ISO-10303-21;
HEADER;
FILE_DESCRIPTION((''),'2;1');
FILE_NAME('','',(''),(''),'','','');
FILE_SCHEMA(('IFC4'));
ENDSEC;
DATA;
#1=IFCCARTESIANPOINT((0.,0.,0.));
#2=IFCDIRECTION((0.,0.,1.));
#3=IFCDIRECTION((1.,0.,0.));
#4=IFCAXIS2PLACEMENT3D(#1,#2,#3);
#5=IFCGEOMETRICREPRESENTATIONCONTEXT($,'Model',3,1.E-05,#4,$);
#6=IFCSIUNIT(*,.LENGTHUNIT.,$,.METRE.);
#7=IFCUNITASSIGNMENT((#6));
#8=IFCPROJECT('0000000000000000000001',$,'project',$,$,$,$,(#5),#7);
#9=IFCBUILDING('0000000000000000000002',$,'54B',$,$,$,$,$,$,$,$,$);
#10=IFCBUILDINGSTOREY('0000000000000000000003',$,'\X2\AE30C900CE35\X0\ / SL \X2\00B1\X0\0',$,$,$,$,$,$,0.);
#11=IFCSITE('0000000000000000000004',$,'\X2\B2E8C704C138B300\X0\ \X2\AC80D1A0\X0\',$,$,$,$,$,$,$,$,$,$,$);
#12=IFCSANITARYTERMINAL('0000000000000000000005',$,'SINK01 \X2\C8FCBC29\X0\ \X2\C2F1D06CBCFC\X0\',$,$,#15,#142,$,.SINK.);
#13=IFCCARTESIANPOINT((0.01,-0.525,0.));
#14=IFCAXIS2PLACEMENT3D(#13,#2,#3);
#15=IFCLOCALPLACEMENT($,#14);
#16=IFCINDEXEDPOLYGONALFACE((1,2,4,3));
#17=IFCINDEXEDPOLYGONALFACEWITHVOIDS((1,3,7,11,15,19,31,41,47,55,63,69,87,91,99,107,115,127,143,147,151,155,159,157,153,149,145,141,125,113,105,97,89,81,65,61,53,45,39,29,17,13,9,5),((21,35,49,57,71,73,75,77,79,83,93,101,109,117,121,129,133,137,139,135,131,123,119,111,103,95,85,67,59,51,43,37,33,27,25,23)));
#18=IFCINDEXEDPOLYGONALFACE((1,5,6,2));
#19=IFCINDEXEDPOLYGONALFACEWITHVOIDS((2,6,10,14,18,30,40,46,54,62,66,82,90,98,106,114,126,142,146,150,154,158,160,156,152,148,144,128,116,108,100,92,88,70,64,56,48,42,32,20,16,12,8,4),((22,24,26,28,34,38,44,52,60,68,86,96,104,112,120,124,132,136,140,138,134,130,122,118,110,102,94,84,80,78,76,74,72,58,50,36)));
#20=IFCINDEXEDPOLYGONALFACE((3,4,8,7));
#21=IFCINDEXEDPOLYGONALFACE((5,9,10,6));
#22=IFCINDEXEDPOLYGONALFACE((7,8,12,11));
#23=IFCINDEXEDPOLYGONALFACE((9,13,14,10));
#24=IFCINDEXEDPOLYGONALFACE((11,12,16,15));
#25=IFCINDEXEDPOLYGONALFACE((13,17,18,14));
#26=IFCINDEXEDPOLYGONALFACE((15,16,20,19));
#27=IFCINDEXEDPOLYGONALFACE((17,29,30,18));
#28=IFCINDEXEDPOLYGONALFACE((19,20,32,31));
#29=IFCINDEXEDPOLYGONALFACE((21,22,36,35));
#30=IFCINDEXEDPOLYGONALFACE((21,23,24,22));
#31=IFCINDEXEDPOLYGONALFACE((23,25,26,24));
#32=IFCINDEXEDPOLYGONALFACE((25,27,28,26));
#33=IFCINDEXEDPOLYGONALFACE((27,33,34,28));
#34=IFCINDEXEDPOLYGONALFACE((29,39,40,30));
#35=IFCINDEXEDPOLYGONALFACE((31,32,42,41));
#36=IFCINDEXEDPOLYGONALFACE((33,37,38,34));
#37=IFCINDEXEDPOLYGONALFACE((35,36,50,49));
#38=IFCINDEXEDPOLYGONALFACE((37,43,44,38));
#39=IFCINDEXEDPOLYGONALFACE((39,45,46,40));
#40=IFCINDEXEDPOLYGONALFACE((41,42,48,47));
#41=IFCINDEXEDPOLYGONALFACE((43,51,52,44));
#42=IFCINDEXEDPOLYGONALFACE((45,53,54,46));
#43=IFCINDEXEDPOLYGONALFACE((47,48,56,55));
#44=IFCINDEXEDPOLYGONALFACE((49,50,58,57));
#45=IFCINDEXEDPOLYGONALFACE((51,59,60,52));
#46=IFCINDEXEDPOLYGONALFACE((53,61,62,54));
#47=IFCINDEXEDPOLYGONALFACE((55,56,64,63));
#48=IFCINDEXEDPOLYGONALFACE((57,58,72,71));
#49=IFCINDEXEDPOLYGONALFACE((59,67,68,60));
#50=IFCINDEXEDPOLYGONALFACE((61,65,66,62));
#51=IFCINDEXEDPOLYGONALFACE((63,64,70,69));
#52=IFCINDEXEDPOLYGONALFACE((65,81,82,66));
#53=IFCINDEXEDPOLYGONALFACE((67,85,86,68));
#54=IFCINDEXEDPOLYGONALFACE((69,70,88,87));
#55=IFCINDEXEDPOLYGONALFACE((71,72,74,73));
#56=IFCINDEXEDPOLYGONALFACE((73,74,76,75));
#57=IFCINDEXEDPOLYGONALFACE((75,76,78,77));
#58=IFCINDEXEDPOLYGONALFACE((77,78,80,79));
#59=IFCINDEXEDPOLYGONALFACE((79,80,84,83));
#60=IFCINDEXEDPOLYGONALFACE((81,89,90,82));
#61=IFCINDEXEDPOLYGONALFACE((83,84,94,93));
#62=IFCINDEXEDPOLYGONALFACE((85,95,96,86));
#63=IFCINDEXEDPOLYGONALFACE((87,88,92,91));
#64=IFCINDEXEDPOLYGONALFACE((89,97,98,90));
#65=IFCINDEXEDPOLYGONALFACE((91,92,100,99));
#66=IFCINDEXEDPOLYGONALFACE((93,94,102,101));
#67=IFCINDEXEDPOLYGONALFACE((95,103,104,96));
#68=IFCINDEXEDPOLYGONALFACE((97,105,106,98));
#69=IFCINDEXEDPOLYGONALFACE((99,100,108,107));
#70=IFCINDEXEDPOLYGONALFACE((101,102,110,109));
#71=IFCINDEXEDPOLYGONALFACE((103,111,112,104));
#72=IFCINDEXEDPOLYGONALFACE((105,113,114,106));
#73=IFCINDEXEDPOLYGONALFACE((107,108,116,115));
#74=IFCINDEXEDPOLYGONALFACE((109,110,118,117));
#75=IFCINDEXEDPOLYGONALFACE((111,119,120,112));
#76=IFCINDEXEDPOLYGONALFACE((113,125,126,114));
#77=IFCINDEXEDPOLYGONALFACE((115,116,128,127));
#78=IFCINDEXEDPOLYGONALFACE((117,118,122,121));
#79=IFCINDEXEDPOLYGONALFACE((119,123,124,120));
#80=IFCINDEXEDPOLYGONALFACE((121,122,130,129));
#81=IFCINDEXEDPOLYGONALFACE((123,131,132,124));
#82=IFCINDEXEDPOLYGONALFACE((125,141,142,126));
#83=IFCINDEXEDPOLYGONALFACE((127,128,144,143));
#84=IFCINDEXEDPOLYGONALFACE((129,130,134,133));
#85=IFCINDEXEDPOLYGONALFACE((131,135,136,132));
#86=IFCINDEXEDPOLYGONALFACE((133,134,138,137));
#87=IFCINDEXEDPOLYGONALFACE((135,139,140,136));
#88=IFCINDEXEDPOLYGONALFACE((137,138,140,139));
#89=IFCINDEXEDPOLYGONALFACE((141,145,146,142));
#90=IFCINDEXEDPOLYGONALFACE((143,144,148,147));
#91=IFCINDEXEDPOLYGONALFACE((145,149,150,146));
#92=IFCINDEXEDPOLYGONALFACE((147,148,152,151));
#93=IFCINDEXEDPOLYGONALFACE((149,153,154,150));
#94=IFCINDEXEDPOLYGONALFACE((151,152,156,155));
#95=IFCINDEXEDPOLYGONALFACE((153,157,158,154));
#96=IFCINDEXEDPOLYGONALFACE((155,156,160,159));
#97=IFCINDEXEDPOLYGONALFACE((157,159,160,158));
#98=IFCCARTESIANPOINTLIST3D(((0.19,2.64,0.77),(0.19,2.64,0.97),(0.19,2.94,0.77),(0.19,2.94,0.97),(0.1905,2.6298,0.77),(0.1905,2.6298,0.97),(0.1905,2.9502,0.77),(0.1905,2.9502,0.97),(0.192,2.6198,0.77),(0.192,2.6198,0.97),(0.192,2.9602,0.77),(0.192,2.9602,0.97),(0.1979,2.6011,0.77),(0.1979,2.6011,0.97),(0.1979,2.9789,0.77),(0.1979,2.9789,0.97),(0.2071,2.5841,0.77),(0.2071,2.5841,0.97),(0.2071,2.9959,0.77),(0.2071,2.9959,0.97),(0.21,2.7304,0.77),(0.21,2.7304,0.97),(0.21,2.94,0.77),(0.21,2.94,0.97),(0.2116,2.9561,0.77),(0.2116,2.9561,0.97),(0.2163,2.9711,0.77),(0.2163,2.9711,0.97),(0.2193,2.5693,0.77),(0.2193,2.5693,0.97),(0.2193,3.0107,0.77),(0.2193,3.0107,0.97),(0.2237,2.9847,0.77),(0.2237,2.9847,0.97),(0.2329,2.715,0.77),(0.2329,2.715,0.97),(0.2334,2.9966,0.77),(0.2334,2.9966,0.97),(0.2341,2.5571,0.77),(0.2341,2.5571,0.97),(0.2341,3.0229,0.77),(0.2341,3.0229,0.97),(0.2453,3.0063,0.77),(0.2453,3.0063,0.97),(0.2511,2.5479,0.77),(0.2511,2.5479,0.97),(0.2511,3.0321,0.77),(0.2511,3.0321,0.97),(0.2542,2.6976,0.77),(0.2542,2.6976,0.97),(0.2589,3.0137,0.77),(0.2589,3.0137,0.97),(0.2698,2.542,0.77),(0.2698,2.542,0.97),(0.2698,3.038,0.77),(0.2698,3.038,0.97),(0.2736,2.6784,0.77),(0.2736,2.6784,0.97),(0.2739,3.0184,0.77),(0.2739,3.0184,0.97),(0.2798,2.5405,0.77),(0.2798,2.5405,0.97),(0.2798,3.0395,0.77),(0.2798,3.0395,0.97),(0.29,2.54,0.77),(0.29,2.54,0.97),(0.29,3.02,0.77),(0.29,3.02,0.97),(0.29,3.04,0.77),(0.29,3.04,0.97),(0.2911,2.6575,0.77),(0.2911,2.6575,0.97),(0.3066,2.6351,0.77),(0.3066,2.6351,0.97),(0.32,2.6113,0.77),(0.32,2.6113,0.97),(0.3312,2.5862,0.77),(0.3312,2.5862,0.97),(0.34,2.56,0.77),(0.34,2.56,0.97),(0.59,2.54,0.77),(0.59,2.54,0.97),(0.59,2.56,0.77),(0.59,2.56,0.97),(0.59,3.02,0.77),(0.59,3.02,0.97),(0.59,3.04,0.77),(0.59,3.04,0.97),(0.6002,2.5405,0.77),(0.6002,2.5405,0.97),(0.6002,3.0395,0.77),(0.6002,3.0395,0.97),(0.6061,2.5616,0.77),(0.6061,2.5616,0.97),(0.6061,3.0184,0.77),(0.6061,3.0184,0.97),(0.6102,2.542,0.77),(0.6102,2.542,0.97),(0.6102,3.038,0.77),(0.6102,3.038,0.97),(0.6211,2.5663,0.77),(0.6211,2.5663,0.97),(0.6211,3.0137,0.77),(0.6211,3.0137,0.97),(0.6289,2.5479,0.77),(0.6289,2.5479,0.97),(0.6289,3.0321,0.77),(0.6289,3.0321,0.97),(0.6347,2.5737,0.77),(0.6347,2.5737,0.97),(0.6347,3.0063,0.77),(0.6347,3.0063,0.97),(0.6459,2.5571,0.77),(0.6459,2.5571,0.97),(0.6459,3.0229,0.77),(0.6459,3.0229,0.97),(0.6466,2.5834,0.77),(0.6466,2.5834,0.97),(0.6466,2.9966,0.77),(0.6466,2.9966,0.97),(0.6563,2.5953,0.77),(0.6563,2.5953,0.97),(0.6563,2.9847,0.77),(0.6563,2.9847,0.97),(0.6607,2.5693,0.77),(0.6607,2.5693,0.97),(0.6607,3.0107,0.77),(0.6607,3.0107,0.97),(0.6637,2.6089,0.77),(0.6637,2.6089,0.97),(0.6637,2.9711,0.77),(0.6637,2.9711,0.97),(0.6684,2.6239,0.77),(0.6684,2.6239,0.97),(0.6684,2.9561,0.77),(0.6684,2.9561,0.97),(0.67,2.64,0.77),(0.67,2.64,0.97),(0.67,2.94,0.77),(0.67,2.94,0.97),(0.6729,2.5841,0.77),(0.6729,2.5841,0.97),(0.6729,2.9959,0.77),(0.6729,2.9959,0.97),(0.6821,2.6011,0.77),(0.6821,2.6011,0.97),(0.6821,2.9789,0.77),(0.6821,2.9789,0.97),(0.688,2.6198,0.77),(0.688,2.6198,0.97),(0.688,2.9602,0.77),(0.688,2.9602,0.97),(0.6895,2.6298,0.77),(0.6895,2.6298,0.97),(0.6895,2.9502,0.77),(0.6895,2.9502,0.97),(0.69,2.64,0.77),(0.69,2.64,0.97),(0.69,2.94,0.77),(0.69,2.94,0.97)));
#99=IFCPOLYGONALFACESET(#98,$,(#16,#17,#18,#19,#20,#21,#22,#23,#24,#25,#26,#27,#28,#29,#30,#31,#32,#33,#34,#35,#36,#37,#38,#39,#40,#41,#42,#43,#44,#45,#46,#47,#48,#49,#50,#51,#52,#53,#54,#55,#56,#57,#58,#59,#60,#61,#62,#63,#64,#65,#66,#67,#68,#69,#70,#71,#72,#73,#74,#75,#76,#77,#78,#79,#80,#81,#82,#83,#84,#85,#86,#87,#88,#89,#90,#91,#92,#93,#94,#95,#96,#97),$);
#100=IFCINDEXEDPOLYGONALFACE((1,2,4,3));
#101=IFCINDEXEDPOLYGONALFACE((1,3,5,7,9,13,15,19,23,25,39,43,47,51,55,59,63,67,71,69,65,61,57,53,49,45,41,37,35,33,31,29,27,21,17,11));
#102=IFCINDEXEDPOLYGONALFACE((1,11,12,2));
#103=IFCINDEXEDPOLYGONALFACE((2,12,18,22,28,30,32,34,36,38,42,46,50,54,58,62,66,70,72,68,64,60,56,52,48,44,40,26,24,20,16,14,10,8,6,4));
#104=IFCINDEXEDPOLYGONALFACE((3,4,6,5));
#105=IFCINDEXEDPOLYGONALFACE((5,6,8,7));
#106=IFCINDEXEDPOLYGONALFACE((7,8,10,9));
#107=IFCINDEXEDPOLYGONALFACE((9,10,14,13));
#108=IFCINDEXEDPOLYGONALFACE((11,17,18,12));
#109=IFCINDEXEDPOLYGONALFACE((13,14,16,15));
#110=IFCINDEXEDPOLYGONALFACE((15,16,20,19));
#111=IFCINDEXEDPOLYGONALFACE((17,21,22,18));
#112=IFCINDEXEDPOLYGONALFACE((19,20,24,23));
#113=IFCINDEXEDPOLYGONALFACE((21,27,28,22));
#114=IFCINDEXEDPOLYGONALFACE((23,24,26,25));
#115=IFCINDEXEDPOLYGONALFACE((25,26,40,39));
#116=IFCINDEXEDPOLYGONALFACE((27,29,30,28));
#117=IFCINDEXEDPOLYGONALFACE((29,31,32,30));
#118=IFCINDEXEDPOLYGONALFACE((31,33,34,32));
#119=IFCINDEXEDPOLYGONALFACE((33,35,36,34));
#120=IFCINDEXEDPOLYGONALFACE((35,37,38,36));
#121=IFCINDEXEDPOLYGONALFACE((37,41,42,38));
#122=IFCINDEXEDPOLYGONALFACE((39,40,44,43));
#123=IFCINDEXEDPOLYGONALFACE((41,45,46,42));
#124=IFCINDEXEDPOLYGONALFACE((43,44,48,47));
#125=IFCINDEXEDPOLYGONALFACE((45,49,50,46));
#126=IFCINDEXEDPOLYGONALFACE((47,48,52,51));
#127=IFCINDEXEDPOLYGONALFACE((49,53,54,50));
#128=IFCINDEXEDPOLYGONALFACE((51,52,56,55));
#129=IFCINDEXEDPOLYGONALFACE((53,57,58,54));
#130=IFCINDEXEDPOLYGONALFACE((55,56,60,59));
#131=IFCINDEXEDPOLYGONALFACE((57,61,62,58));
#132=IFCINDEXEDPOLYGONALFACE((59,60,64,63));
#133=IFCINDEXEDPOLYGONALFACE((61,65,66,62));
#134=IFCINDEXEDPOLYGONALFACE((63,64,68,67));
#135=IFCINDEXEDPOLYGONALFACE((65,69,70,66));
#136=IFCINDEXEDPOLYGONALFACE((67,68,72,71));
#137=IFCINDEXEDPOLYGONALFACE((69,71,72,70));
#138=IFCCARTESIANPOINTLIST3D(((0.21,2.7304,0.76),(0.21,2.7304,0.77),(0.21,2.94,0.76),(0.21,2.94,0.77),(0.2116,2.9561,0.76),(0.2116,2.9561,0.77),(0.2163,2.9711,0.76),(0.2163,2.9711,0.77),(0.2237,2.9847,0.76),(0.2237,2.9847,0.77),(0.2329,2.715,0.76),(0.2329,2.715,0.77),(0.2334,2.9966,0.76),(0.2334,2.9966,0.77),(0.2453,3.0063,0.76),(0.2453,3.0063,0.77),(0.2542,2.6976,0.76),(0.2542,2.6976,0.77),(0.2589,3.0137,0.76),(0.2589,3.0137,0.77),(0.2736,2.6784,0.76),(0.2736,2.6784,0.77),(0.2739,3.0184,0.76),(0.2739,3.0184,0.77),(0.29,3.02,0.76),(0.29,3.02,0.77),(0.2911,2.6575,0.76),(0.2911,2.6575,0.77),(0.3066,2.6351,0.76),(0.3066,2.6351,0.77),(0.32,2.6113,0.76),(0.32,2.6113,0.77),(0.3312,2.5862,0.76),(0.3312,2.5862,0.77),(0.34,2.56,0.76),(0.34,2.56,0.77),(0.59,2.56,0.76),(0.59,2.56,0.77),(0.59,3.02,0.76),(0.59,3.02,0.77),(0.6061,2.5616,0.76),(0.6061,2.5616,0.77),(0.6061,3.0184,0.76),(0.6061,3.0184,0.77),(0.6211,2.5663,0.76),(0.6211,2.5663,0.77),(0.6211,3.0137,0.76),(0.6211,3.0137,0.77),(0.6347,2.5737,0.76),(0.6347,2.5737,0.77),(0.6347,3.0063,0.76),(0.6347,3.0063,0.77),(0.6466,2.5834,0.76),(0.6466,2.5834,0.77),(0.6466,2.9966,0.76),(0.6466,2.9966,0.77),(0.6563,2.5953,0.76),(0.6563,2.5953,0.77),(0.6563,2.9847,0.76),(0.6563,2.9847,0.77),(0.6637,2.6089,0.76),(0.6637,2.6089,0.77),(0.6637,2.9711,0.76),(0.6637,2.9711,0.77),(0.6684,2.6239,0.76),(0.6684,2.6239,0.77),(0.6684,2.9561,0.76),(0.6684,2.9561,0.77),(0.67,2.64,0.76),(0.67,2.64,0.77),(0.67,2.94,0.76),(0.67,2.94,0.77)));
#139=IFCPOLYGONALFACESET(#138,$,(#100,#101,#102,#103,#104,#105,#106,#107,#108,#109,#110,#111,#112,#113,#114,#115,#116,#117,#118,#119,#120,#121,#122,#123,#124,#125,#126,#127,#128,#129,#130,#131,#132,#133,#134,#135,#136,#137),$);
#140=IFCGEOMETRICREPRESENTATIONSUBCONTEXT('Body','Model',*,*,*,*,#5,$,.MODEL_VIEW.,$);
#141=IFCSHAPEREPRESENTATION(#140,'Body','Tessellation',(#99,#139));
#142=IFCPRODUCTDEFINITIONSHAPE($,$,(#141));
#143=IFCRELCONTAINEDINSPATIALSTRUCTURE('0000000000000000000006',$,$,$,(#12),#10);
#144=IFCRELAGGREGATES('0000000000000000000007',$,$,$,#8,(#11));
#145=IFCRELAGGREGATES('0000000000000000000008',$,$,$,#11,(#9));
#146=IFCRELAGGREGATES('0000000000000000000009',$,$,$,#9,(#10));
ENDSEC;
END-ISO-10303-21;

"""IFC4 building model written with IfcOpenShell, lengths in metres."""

from ifc_helpers import new_model, si_unit, frame, origin_with_axes, place, context, subcontext, project, spatial, polyline, outline, extrude, element, save


model = new_model("IFC4")

# Units and contexts
model_context = context("Model", 3, precision=1e-05, world=origin_with_axes())
body_context = subcontext(model_context, "Body", "Model", "MODEL_VIEW")
ifc_project = project(units=[si_unit("LENGTHUNIT", "METRE")], contexts=[model_context])

# Site, building, storey
site = spatial("IfcSite", under=ifc_project, Name="단위세대 검토")
building = spatial("IfcBuilding", under=site, Name="54B")
storey = spatial("IfcBuildingStorey", under=building, Name="기준층 / SL ±0", Elevation=0.0)

# Sanitary terminal
sanitary_terminal_1_placement = place(None, frame((0.01, -0.525, 0.0), z_axis=(0.0, 0.0, 1.0), x_axis=(1.0, 0.0, 0.0)))
element("IfcSanitaryTerminal", 1, at=sanitary_terminal_1_placement, inside=storey, Name="SINK01 주방 싱크볼", PredefinedType="SINK", context=body_context, shape_type="SweptSolid", body=[
    extrude(outline(polyline([(0.69, 2.64), (0.6895, 2.6298), (0.688, 2.6198), (0.6821, 2.6011), (0.6729, 2.5841), (0.6607, 2.5693), (0.6459, 2.5571), (0.6289, 2.5479), (0.6102, 2.542), (0.6002, 2.5405), (0.59, 2.54), (0.29, 2.54), (0.2798, 2.5405), (0.2698, 2.542), (0.2511, 2.5479), (0.2341, 2.5571), (0.2193, 2.5693), (0.2071, 2.5841), (0.1979, 2.6011), (0.192, 2.6198), (0.1905, 2.6298), (0.19, 2.64), (0.19, 2.94), (0.1905, 2.9502), (0.192, 2.9602), (0.1979, 2.9789), (0.2071, 2.9959), (0.2193, 3.0107), (0.2341, 3.0229), (0.2511, 3.0321), (0.2698, 3.038), (0.2798, 3.0395), (0.29, 3.04), (0.59, 3.04), (0.6002, 3.0395), (0.6102, 3.038), (0.6289, 3.0321), (0.6459, 3.0229), (0.6607, 3.0107), (0.6729, 2.9959), (0.6821, 2.9789), (0.688, 2.9602), (0.6895, 2.9502), (0.69, 2.94), (0.69, 2.64)]), holes=[polyline([(0.6684, 2.9561), (0.6637, 2.9711), (0.6563, 2.9847), (0.6466, 2.9966), (0.6347, 3.0063), (0.6211, 3.0137), (0.6061, 3.0184), (0.59, 3.02), (0.29, 3.02), (0.2739, 3.0184), (0.2589, 3.0137), (0.2453, 3.0063), (0.2334, 2.9966), (0.2237, 2.9847), (0.2163, 2.9711), (0.2116, 2.9561), (0.21, 2.94), (0.21, 2.7304), (0.2329, 2.715), (0.2542, 2.6976), (0.2736, 2.6784), (0.2911, 2.6575), (0.3066, 2.6351), (0.32, 2.6113), (0.3312, 2.5862), (0.34, 2.56), (0.59, 2.56), (0.6061, 2.5616), (0.6211, 2.5663), (0.6347, 2.5737), (0.6466, 2.5834), (0.6563, 2.5953), (0.6637, 2.6089), (0.6684, 2.6239), (0.67, 2.64), (0.67, 2.94), (0.6684, 2.9561)])]), frame((0.0, 0.0, 0.77)), (0.0, 0.0, 1.0), 0.2),
    extrude(outline(polyline([(0.67, 2.94), (0.67, 2.64), (0.6684, 2.6239), (0.6637, 2.6089), (0.6563, 2.5953), (0.6466, 2.5834), (0.6347, 2.5737), (0.6211, 2.5663), (0.6061, 2.5616), (0.59, 2.56), (0.34, 2.56), (0.3312, 2.5862), (0.32, 2.6113), (0.3066, 2.6351), (0.2911, 2.6575), (0.2736, 2.6784), (0.2542, 2.6976), (0.2329, 2.715), (0.21, 2.7304), (0.21, 2.94), (0.2116, 2.9561), (0.2163, 2.9711), (0.2237, 2.9847), (0.2334, 2.9966), (0.2453, 3.0063), (0.2589, 3.0137), (0.2739, 3.0184), (0.29, 3.02), (0.59, 3.02), (0.6061, 3.0184), (0.6211, 3.0137), (0.6347, 3.0063), (0.6466, 2.9966), (0.6563, 2.9847), (0.6637, 2.9711), (0.6684, 2.9561), (0.67, 2.94)])), frame((0.0, 0.0, 0.76)), (0.0, 0.0, 1.0), 0.01),
])

save(model, "model.ifc")
